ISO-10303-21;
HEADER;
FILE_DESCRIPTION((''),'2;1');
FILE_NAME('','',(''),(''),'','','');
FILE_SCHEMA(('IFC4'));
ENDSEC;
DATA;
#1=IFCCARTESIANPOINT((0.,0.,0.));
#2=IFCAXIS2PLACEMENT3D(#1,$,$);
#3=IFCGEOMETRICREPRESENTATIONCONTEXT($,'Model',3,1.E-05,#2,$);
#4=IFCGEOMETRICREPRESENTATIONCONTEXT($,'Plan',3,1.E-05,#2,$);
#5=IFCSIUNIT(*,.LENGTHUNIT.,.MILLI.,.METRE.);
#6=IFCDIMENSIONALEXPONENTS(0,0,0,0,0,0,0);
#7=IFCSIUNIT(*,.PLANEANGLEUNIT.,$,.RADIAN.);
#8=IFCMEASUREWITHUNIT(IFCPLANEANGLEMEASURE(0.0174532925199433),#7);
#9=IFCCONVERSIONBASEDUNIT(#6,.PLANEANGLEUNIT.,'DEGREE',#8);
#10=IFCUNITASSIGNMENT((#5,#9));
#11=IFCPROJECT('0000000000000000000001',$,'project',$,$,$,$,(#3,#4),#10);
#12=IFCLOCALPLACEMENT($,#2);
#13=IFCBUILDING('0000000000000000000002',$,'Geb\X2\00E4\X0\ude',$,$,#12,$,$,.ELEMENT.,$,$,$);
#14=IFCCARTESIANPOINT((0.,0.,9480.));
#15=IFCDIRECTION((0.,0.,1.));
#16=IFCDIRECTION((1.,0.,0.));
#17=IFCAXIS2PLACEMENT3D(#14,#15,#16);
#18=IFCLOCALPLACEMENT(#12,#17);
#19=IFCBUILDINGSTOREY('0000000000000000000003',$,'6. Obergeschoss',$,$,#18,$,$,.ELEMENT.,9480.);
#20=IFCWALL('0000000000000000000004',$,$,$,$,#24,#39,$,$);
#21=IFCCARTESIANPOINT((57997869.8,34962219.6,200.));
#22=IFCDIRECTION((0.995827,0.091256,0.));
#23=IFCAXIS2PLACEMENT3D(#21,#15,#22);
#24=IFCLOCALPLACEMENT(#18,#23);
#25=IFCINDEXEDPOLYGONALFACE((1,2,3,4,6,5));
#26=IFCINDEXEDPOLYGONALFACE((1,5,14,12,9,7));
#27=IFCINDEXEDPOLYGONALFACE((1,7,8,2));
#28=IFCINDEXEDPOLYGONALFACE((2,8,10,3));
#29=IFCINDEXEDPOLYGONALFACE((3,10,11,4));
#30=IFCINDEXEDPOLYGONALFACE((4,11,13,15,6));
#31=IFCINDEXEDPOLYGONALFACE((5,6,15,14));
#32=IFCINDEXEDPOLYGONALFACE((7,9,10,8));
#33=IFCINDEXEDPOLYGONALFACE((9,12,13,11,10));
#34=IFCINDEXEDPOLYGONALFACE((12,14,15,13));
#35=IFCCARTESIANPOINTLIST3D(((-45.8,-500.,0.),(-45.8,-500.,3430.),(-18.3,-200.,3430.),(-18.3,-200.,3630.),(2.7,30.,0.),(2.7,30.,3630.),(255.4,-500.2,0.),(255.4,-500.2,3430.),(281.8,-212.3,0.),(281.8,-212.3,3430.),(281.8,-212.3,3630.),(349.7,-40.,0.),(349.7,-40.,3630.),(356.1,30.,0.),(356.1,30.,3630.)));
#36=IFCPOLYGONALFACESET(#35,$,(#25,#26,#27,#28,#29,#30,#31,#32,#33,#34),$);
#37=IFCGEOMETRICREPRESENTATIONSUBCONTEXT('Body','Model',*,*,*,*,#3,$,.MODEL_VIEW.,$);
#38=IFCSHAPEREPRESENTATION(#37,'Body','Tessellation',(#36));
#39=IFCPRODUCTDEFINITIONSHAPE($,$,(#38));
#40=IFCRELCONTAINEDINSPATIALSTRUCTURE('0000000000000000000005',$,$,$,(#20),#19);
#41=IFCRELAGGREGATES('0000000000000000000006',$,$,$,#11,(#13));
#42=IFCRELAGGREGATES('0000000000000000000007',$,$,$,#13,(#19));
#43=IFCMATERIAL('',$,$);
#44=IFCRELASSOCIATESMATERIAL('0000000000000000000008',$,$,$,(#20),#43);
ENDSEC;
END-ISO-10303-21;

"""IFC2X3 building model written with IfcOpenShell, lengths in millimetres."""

from ifc_helpers import new_model, entity, si_unit, converted_unit, frame, origin, origin_with_axes, place, context, subcontext, project, spatial, polyline, outline, extrude, clip, bounded_halfspace, material, element, save


model = new_model("IFC2X3")

# Units and contexts
model_context = context("Model", 3, precision=1e-05, world=origin())
plan_context = context("Plan", 3, precision=1e-05, world=origin())
body_context = subcontext(model_context, "Body", "Model", "MODEL_VIEW")
ifc_project = project(units=[si_unit("LENGTHUNIT", "METRE", prefix="MILLI"), converted_unit("PLANEANGLEUNIT", "DEGREE", entity("IfcPlaneAngleMeasure", 0.0174532925199433), si_unit("PLANEANGLEUNIT", "RADIAN"), dimensions=[0, 0, 0, 0, 0, 0, 0])], contexts=[model_context, plan_context])

# Building, storey
building_placement = place(None, origin())
building = spatial("IfcBuilding", under=ifc_project, at=building_placement, Name="Gebäude", CompositionType="ELEMENT")
storey_placement = place(building_placement, frame((0.0, 0.0, 9480.0), z_axis=(0.0, 0.0, 1.0), x_axis=(1.0, 0.0, 0.0)))
storey = spatial("IfcBuildingStorey", under=building, at=storey_placement, Name="6. Obergeschoss", CompositionType="ELEMENT", Elevation=9480.0)

# Wall
ifc_material_1 = material(Name="")
wall_1_placement = place(storey_placement, frame((57997869.8, 34962219.6, 200.0), z_axis=(0.0, 0.0, 1.0), x_axis=(0.995827, 0.091256, 0.0)))
element("IfcWall", 1, at=wall_1_placement, inside=storey, material=ifc_material_1, context=body_context, shape_type="Clipping", body=[
    clip(clip(extrude(outline(polyline([(-45.8, -500.0), (255.4, -500.2), (281.8, -212.3), (349.7, -40.0), (356.1, 30.0), (-228.2, 30.0), (2.7, 30.0), (0.0, 0.0), (-45.8, -500.0)])), origin_with_axes(), (0.0, 0.0, 1.0), 3630.0), bounded_halfspace(frame((-45.8, -500.0, 3430.0), z_axis=(0.0, 0.0, -1.0), x_axis=(1.0, 0.0, 0.0)), True, origin(), polyline([(-45.8, -500.0), (255.4, -500.2), (281.8, -212.3), (-18.3, -200.0), (-45.8, -500.0)]))), bounded_halfspace(frame((-18.3, -200.0, 3630.0), z_axis=(0.0, 0.0, -1.0), x_axis=(1.0, 0.0, 0.0)), True, origin(), polyline([(-18.3, -200.0), (281.8, -212.3), (349.7, -40.0), (356.1, 30.0), (-228.2, 30.0), (2.7, 30.0), (-18.3, -200.0)]))),
])

save(model, "model.ifc")
